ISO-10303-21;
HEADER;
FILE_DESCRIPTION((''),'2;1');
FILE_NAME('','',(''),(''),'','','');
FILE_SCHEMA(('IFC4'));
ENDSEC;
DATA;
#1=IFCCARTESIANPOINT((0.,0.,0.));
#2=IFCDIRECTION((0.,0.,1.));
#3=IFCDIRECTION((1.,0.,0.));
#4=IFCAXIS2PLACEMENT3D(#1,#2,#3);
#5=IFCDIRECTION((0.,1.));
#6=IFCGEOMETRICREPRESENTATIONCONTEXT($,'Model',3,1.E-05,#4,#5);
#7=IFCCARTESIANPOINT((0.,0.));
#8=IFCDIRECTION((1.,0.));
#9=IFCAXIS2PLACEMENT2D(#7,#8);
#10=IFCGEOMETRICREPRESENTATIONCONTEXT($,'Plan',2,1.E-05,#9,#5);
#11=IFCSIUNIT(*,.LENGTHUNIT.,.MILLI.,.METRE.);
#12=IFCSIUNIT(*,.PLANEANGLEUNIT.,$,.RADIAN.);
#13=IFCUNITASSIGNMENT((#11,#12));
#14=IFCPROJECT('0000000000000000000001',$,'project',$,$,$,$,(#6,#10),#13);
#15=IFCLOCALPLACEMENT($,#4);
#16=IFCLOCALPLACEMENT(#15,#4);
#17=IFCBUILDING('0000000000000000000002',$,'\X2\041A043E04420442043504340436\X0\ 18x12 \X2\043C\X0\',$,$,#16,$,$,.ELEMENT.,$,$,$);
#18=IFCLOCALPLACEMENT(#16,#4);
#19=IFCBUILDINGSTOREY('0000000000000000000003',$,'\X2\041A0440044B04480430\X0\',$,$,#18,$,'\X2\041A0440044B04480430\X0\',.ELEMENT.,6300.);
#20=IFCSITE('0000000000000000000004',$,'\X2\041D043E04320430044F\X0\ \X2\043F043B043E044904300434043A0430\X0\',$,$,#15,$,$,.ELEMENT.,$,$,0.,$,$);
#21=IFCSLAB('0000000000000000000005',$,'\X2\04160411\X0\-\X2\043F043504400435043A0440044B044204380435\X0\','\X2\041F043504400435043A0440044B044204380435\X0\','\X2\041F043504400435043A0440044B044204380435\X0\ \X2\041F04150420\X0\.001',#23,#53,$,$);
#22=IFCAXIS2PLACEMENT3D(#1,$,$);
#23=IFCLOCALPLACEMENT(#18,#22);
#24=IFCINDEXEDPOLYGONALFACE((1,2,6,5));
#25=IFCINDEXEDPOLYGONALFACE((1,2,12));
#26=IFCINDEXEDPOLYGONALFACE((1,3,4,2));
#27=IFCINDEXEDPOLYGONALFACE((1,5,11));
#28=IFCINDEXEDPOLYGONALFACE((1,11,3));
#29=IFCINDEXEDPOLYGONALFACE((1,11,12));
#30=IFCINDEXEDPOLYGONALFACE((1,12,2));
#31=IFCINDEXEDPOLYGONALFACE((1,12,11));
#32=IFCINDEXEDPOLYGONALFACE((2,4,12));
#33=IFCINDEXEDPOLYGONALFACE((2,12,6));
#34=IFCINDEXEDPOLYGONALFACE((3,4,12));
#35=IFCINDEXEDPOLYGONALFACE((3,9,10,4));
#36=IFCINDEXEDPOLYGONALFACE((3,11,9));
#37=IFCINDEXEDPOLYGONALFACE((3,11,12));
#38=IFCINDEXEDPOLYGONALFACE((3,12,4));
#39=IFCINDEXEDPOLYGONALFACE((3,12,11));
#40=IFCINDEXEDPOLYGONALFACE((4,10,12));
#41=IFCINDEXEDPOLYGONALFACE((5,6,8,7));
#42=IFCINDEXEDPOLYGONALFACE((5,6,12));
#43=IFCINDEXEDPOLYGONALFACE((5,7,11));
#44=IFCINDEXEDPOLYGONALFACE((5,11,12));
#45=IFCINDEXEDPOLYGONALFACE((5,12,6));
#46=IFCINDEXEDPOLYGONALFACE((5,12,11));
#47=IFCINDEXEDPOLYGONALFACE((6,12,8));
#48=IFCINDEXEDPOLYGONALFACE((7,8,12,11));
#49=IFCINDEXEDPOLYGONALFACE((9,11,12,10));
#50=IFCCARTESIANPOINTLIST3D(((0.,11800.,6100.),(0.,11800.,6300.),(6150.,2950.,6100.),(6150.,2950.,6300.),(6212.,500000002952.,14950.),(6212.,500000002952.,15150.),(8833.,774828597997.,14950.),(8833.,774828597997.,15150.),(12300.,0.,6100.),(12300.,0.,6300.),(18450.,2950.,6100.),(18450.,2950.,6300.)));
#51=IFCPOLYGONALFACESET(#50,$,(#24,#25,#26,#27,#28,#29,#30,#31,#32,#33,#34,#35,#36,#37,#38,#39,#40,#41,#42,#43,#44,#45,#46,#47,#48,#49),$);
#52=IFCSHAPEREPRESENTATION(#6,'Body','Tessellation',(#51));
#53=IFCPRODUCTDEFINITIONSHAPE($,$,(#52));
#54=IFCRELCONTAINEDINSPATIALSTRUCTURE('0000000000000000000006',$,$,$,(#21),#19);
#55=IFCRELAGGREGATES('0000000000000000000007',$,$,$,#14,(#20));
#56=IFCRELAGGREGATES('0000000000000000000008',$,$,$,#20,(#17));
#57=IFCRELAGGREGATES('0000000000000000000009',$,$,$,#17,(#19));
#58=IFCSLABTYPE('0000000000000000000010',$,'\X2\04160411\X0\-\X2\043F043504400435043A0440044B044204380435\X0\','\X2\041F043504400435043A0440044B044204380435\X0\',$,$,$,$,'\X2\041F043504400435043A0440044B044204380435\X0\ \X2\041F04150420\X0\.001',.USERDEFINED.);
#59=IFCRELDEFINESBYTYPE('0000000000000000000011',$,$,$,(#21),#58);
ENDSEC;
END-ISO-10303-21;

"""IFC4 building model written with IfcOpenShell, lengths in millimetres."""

from ifc_helpers import new_model, si_unit, direction, frame, origin_with_axes, origin_2d_with_axis, place, context, project, spatial, polyline, segment, composite_curve, outline, extrude, type_object, element, save


model = new_model("IFC4")

# Units and contexts
model_context = context("Model", 3, precision=1e-05, world=origin_with_axes(), true_north=direction((0.0, 1.0)))
plan_context = context("Plan", 2, precision=1e-05, world=origin_2d_with_axis(), true_north=direction((0.0, 1.0)))
ifc_project = project(units=[si_unit("LENGTHUNIT", "METRE", prefix="MILLI"), si_unit("PLANEANGLEUNIT", "RADIAN")], contexts=[model_context, plan_context])

# Site, building, storey
site_placement = place(None, origin_with_axes())
site = spatial("IfcSite", under=ifc_project, at=site_placement, Name="Новая площадка", CompositionType="ELEMENT", RefElevation=0.0)
building_placement = place(site_placement, origin_with_axes())
building = spatial("IfcBuilding", under=site, at=building_placement, Name="Коттедж 18x12 м", CompositionType="ELEMENT")
storey_placement = place(building_placement, origin_with_axes())
storey = spatial("IfcBuildingStorey", under=building, at=storey_placement, Name="Крыша", LongName="Крыша", CompositionType="ELEMENT", Elevation=6300.0)

# Slab
slab_type = type_object("IfcSlabType", Name="ЖБ-перекрытие", Description="Перекрытие", ElementType="Перекрытие ПЕР.001", PredefinedType="USERDEFINED")
slab_placement = place(None, frame((0.0, 2950.0, 6100.0), z_axis=(0.0, 0.0, 1.0), x_axis=(1.0, 0.0, 0.0)))
element("IfcSlab", 1, at=slab_placement, inside=storey, type_object=slab_type, Name="ЖБ-перекрытие", Description="Перекрытие", ObjectType="Перекрытие ПЕР.001", context=model_context, shape_type="SweptSolid", body=[
    extrude(outline(composite_curve([segment(polyline([(6150.0, 0.0), (6150.0, -2950.0)]), True, "CONTINUOUS"), segment(polyline([(6150.0, -2950.0), (12300.0, -2950.0)]), True, "CONTINUOUS"), segment(polyline([(12300.0, -2950.0), (12300.0, 0.0)]), True, "CONTINUOUS"), segment(polyline([(12300.0, 0.0), (18450.0, 0.0)]), True, "CONTINUOUS"), segment(polyline([(18450.0, 0.0), (18450.0, 8850.0)]), True, "CONTINUOUS"), segment(polyline([(18450.0, 8850.0), (8833.0, 774828595047.0, 8850.0)]), True, "CONTINUOUS"), segment(polyline([(8833.0, 774828595047.0, 8850.0), (6212.0, 500000000002.0, 8850.0)]), True, "CONTINUOUS"), segment(polyline([(6212.0, 500000000002.0, 8850.0), (0.0, 8850.0)]), True, "CONTINUOUS"), segment(polyline([(0.0, 8850.0), (0.0, 0.0)]), True, "CONTINUOUS"), segment(polyline([(0.0, 0.0), (6150.0, 0.0)]), True, "DISCONTINUOUS")], self_intersect=False)), origin_with_axes(), (0.0, 0.0, 1.0), 200.0),
])

save(model, "model.ifc")
